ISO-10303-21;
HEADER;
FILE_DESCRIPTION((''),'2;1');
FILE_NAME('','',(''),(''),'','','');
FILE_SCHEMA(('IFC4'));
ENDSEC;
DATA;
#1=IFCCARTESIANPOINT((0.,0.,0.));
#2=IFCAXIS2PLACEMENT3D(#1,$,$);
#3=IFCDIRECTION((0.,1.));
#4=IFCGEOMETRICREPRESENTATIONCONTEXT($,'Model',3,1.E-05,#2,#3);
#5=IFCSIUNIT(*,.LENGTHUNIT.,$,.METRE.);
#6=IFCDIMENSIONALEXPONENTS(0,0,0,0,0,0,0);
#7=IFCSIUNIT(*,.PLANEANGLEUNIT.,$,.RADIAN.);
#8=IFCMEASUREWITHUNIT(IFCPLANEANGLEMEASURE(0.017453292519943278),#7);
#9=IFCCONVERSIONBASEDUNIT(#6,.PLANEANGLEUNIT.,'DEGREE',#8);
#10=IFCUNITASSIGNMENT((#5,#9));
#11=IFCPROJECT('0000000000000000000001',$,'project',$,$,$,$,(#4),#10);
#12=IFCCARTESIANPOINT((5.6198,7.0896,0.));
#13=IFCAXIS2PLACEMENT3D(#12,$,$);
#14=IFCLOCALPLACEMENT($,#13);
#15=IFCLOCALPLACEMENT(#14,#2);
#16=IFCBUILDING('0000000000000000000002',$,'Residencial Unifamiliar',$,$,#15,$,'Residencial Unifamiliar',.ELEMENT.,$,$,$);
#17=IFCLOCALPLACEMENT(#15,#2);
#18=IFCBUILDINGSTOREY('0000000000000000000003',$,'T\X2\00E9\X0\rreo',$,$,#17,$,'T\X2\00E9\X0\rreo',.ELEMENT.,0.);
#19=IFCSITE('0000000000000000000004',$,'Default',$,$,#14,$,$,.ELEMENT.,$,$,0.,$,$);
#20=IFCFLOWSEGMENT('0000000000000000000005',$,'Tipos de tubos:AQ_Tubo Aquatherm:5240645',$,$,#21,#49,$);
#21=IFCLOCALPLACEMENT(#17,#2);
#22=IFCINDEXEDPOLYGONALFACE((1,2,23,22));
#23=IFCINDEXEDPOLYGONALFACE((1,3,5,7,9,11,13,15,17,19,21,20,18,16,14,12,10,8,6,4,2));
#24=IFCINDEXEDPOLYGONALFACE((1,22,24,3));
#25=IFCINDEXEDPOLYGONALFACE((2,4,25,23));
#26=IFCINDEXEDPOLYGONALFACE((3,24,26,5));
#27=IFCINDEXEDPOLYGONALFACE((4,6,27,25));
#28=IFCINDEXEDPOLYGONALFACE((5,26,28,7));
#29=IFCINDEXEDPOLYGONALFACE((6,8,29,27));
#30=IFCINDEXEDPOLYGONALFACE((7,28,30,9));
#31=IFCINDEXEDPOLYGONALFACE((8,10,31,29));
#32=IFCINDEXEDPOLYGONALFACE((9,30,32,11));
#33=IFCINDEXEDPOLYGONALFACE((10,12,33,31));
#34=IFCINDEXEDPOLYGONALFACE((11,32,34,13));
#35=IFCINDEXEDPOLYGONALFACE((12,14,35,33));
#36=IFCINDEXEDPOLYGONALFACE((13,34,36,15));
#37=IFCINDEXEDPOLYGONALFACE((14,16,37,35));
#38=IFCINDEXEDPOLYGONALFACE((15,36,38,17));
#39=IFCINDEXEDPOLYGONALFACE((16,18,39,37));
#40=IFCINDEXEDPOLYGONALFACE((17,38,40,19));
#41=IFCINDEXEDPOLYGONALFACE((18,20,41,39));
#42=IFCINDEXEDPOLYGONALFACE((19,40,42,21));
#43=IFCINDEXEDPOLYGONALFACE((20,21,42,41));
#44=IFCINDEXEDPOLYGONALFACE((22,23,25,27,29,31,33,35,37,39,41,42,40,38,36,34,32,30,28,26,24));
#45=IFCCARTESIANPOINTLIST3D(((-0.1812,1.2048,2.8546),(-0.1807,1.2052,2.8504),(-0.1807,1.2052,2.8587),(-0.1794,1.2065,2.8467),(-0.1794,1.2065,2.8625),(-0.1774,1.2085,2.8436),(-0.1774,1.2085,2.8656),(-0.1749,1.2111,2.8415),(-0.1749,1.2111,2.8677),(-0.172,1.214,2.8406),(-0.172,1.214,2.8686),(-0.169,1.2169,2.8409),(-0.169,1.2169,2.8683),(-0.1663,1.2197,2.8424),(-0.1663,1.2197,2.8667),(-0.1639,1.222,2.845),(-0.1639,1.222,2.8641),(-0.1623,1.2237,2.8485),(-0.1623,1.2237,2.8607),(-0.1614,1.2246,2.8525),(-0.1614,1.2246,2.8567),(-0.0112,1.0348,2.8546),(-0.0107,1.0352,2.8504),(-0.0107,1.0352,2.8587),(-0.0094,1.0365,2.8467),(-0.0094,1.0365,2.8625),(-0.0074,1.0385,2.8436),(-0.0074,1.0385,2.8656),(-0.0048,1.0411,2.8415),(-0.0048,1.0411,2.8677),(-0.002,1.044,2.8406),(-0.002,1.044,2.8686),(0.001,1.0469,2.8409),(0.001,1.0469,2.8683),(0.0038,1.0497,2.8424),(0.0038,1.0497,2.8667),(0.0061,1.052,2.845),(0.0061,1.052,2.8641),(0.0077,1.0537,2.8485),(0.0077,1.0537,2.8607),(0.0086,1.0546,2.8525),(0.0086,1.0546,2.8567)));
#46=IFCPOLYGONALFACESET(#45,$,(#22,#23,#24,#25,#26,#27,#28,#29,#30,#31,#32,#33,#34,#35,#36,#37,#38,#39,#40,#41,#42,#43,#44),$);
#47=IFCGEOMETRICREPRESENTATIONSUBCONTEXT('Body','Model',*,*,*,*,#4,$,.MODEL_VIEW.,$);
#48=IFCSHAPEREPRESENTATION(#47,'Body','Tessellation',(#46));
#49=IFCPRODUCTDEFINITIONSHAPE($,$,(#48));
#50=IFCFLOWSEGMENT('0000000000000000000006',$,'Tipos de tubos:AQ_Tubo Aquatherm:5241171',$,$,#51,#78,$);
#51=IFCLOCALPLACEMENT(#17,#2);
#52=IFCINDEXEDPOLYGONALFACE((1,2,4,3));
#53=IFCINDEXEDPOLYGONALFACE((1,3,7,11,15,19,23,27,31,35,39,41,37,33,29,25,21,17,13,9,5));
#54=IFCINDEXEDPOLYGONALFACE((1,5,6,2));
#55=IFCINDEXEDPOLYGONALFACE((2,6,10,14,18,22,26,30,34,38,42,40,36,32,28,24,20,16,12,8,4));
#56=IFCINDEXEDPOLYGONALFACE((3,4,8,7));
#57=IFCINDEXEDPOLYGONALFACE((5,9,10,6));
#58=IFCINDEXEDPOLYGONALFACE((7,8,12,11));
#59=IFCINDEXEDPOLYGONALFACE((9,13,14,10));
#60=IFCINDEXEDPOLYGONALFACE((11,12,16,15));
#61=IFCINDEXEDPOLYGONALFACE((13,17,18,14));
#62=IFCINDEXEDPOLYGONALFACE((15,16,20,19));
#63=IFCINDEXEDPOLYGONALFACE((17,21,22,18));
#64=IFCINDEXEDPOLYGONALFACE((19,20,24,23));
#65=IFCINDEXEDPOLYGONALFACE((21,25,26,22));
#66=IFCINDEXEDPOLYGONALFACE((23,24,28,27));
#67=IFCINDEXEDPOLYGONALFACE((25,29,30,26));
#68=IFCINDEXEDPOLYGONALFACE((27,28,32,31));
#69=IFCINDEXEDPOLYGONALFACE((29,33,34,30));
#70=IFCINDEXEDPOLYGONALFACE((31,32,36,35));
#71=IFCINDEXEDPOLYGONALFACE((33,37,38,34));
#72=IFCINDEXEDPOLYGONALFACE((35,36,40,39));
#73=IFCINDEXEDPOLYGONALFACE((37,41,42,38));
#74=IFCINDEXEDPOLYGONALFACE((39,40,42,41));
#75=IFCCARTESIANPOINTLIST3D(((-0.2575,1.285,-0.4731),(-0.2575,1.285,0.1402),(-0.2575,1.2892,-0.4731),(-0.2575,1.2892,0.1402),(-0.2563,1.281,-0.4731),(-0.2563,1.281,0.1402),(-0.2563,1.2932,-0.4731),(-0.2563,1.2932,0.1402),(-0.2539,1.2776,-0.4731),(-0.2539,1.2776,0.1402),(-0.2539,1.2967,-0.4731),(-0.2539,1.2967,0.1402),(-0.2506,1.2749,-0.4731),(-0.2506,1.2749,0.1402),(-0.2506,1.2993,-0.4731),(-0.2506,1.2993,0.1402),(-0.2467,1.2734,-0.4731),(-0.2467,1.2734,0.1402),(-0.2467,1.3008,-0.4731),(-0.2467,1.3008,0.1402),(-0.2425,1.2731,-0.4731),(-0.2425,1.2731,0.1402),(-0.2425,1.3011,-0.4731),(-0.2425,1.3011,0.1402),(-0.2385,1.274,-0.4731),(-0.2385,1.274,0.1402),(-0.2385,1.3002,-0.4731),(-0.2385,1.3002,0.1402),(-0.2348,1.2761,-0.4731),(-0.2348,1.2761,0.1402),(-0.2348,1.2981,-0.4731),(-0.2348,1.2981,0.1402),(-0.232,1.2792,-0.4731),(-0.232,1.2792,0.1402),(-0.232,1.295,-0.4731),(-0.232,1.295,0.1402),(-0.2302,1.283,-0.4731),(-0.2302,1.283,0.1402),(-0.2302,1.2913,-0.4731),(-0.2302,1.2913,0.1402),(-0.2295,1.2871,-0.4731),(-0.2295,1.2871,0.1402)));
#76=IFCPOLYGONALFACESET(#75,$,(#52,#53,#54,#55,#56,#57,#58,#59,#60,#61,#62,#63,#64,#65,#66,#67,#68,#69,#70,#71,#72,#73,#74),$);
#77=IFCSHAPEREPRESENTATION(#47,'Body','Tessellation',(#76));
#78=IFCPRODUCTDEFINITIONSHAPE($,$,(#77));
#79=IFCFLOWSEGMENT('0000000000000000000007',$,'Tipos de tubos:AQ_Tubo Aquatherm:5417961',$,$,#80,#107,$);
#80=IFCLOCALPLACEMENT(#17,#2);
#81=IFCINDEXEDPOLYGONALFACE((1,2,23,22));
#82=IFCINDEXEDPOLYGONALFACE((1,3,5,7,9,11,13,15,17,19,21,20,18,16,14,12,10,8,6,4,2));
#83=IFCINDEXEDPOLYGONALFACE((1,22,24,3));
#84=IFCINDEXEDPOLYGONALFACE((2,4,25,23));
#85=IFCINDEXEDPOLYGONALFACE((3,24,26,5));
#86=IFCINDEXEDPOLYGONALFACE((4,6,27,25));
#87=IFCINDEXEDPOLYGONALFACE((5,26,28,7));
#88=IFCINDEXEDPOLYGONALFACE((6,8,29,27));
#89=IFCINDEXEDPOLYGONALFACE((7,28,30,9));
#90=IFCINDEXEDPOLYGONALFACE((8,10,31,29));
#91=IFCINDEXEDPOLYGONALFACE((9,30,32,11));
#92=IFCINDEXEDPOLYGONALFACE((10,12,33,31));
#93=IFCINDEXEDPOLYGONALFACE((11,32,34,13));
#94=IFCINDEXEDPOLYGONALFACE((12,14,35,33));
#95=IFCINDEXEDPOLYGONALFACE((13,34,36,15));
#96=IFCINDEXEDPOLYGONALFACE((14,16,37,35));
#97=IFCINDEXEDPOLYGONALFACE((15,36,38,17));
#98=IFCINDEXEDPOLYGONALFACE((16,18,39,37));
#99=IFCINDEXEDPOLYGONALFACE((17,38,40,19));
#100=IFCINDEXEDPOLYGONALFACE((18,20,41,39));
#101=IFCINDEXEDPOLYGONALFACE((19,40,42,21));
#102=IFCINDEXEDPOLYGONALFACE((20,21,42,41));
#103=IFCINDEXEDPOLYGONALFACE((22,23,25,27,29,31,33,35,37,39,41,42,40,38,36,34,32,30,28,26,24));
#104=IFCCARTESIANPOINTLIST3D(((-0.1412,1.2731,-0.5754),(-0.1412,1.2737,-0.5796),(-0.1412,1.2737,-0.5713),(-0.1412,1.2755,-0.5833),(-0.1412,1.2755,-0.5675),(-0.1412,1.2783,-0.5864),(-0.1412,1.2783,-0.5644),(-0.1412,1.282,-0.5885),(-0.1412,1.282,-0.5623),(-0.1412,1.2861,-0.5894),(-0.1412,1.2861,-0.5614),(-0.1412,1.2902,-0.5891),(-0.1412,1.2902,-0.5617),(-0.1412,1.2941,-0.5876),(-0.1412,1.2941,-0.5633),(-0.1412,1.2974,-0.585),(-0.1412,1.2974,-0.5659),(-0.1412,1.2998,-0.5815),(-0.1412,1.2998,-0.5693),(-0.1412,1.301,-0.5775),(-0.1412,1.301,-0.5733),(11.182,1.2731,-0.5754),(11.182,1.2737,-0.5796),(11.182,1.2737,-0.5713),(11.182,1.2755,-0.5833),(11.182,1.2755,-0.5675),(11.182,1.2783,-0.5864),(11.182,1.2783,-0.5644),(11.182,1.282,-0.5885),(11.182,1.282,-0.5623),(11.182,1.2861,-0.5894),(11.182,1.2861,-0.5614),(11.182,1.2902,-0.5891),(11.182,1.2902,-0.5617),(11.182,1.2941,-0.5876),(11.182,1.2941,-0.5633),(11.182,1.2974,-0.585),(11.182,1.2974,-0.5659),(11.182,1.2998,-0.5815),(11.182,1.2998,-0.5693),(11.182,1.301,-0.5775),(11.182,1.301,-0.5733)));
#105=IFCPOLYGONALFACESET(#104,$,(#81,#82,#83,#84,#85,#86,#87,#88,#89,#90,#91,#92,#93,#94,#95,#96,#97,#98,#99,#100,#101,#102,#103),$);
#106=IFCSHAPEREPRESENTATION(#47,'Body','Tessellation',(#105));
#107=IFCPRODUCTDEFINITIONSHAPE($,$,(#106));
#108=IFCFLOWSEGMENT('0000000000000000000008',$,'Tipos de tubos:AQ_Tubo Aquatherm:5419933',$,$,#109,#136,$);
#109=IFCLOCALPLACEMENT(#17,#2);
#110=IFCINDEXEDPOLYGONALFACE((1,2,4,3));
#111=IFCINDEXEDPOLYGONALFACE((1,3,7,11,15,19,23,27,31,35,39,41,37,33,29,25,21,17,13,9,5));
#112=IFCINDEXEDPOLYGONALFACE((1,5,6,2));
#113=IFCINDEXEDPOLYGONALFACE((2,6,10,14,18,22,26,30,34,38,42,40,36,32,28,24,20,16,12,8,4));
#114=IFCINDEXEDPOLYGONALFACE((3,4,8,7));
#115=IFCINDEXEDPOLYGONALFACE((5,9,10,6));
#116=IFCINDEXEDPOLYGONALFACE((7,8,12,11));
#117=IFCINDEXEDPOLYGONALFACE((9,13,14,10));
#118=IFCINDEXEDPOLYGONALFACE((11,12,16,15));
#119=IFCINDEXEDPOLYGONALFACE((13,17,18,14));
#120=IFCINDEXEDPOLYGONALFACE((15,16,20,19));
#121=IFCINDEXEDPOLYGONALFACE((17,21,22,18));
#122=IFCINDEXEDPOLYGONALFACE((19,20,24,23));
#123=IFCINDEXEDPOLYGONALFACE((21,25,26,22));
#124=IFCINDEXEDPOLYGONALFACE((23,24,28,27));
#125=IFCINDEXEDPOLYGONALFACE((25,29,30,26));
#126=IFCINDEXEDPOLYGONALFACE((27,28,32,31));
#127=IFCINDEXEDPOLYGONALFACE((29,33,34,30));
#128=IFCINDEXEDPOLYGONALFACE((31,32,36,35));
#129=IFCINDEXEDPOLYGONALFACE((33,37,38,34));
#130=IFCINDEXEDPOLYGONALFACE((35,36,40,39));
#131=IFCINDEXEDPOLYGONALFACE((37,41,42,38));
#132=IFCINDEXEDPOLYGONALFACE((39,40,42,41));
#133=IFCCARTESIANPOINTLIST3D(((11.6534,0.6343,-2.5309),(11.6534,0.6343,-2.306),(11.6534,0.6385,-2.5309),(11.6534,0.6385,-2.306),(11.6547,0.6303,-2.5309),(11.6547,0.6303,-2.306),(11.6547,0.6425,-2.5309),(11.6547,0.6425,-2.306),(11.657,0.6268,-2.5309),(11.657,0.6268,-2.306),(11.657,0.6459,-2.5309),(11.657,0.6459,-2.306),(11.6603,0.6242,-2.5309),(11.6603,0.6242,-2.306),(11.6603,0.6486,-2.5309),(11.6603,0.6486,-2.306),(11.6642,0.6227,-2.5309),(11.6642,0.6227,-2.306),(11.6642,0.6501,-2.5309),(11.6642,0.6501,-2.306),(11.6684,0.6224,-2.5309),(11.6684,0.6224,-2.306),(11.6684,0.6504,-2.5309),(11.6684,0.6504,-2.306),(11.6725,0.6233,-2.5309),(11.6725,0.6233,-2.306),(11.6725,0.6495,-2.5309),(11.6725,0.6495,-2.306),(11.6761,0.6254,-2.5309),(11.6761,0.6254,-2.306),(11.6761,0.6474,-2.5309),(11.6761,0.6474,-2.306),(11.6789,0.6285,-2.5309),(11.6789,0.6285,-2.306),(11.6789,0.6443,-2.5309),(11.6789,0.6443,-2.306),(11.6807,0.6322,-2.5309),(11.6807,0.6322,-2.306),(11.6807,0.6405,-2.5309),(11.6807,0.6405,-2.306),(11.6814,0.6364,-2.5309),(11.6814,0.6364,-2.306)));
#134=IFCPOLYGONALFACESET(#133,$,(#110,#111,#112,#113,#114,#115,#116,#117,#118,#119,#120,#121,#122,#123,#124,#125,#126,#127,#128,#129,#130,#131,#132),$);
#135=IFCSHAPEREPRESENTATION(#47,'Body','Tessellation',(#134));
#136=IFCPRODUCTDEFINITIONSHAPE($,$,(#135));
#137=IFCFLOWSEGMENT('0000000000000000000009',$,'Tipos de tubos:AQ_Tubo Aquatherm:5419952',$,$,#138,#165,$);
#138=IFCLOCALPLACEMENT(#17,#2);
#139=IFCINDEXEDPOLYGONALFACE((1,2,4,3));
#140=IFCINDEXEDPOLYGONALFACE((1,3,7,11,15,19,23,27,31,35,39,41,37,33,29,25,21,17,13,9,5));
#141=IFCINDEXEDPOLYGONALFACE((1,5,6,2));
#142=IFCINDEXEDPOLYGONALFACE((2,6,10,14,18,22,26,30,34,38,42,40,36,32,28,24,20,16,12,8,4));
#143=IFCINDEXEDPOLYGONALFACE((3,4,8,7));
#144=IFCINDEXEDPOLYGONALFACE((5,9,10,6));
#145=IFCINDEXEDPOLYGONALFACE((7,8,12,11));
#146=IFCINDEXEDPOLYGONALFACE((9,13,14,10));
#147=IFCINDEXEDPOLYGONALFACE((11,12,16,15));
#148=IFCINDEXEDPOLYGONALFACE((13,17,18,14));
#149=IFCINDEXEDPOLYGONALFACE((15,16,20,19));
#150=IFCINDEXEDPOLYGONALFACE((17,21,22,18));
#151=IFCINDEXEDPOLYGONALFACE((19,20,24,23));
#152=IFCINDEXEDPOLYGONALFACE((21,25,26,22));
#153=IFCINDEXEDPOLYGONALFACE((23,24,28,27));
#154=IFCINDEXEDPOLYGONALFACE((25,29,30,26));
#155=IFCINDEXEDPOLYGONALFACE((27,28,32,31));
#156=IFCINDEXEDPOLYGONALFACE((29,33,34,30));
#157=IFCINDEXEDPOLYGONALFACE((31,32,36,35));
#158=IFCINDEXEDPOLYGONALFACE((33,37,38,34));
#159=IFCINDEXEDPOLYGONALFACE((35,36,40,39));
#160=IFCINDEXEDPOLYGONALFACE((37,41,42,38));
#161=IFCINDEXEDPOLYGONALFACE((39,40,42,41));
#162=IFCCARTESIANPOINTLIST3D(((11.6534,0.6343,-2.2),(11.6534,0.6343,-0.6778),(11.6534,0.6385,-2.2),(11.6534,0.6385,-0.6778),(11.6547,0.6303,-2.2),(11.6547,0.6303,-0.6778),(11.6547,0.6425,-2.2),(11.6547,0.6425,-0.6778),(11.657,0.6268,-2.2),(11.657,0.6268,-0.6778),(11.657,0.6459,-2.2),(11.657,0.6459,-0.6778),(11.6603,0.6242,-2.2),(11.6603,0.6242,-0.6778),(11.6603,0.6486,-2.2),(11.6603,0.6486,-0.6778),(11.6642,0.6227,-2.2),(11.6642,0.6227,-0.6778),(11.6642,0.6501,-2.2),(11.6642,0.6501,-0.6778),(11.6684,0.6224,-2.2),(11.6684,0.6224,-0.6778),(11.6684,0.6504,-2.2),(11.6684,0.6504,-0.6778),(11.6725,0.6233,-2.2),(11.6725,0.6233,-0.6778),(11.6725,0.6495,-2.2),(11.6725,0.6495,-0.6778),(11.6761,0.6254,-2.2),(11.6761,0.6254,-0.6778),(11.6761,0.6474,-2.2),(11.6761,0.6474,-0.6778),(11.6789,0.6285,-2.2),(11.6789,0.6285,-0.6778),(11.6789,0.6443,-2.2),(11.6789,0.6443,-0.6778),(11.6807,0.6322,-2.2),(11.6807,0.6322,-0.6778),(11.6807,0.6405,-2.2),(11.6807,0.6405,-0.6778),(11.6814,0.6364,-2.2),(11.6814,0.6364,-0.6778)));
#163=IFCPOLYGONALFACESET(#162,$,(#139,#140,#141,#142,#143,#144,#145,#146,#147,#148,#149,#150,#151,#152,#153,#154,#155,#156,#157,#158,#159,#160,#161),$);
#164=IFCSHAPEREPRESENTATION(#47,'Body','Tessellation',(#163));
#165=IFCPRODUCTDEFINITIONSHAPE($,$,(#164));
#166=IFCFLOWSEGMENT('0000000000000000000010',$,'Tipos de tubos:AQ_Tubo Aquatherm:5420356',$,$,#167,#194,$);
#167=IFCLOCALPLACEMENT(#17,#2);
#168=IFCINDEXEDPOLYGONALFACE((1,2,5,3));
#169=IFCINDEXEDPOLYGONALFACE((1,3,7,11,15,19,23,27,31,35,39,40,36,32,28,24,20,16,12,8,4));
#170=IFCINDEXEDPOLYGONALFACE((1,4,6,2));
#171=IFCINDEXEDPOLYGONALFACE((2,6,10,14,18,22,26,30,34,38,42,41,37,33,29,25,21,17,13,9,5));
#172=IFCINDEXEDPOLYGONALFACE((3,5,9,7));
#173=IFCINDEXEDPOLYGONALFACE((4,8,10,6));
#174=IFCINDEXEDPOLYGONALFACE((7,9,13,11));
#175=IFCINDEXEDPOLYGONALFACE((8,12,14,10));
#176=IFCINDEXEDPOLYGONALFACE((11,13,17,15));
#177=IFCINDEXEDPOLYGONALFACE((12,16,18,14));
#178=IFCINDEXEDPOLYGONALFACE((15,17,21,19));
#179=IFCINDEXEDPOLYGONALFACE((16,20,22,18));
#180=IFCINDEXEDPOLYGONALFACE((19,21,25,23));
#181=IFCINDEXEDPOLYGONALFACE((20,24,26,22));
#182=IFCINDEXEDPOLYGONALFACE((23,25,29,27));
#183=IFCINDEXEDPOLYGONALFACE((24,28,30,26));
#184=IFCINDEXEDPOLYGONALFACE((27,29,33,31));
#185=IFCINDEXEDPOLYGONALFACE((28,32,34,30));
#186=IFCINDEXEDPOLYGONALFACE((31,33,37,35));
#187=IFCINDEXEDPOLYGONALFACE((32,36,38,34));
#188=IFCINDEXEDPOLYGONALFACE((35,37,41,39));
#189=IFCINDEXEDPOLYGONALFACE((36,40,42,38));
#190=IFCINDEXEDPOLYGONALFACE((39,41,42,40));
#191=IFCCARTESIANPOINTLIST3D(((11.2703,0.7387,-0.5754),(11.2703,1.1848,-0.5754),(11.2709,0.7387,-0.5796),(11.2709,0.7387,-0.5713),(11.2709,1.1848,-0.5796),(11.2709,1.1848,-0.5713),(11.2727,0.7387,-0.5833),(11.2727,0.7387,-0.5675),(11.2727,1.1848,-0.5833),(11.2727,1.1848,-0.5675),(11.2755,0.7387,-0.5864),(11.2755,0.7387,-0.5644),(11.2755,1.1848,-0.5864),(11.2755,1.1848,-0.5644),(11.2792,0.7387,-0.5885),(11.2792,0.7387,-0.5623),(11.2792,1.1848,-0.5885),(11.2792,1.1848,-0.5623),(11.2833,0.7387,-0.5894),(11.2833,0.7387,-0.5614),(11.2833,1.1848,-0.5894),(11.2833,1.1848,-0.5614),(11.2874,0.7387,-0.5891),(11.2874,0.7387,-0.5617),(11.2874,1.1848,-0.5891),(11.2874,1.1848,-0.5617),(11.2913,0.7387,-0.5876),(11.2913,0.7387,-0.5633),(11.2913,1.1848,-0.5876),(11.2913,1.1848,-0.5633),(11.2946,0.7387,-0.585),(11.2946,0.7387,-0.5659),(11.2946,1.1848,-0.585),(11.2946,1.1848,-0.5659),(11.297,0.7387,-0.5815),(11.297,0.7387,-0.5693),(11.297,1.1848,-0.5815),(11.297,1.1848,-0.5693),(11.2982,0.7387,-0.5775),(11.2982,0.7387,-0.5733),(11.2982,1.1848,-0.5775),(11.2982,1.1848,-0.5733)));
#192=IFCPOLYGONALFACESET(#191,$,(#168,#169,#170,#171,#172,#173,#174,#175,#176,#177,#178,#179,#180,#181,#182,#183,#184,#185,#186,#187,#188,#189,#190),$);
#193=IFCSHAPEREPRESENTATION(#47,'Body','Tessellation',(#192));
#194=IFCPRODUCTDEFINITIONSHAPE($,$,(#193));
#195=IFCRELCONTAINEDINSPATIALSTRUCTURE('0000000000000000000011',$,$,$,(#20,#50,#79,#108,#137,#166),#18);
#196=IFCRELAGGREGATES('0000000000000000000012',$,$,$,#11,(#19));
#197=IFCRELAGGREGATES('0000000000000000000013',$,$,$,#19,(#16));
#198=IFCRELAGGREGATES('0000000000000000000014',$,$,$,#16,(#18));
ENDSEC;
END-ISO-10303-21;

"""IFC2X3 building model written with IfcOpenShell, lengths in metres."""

from ifc_helpers import new_model, entity, si_unit, converted_unit, direction, frame, frame_2d, origin, origin_2d_with_axis, place, context, subcontext, project, spatial, circle, extrude, element, save


model = new_model("IFC2X3")

# Units and contexts
model_context = context("Model", 3, precision=1e-05, world=origin(), true_north=direction((0.0, 1.0)))
body_context = subcontext(model_context, "Body", "Model", "MODEL_VIEW")
ifc_project = project(units=[si_unit("LENGTHUNIT", "METRE"), converted_unit("PLANEANGLEUNIT", "DEGREE", entity("IfcPlaneAngleMeasure", 0.017453292519943278), si_unit("PLANEANGLEUNIT", "RADIAN"), dimensions=[0, 0, 0, 0, 0, 0, 0])], contexts=[model_context])

# Site, building, storey
site_placement = place(None, frame((5.6198, 7.0896, 0.0)))
site = spatial("IfcSite", under=ifc_project, at=site_placement, Name="Default", CompositionType="ELEMENT", RefElevation=0.0)
building_placement = place(site_placement, origin())
building = spatial("IfcBuilding", under=site, at=building_placement, Name="Residencial Unifamiliar", LongName="Residencial Unifamiliar", CompositionType="ELEMENT")
storey_placement = place(building_placement, origin())
storey = spatial("IfcBuildingStorey", under=building, at=storey_placement, Name="Térreo", LongName="Térreo", CompositionType="ELEMENT", Elevation=0.0)

# Flow segments
flow_segment_1_placement = place(storey_placement, origin())
element("IfcFlowSegment", 1, at=flow_segment_1_placement, inside=storey, Name="Tipos de tubos:AQ_Tubo Aquatherm:5240645", context=body_context, shape_type="SweptSolid", body=[
    extrude(circle(Radius=0.0141, at=frame_2d((0.0, 0.0), x_axis=(1.0, 0.0))), frame((-0.1712, 1.2147, 2.8546), z_axis=(0.707107, -0.707107, 0.0), x_axis=(-0.707107, -0.707107, 0.0)), (0.0, 0.0, 1.0), 0.2404),
])
flow_segment_2_placement = place(storey_placement, origin())
element("IfcFlowSegment", 2, at=flow_segment_2_placement, inside=storey, Name="Tipos de tubos:AQ_Tubo Aquatherm:5241171", context=body_context, shape_type="SweptSolid", body=[
    extrude(circle(Radius=0.0141, at=origin_2d_with_axis()), frame((-0.2436, 1.2871, -0.4731)), (0.0, 0.0, 1.0), 0.6133),
])
flow_segment_3_placement = place(storey_placement, origin())
element("IfcFlowSegment", 3, at=flow_segment_3_placement, inside=storey, Name="Tipos de tubos:AQ_Tubo Aquatherm:5417961", context=body_context, shape_type="SweptSolid", body=[
    extrude(circle(Radius=0.0141, at=frame_2d((0.0, 0.0), x_axis=(1.0, 0.0))), frame((-0.1412, 1.2871, -0.5754), z_axis=(1.0, 0.0, 0.0), x_axis=(0.0, -1.0, 0.0)), (0.0, 0.0, 1.0), 11.3232),
])
flow_segment_4_placement = place(storey_placement, origin())
element("IfcFlowSegment", 4, at=flow_segment_4_placement, inside=storey, Name="Tipos de tubos:AQ_Tubo Aquatherm:5419933", context=body_context, shape_type="SweptSolid", body=[
    extrude(circle(Radius=0.0141, at=origin_2d_with_axis()), frame((11.6673, 0.6364, -2.5309)), (0.0, 0.0, 1.0), 0.2249),
])
flow_segment_5_placement = place(storey_placement, origin())
element("IfcFlowSegment", 5, at=flow_segment_5_placement, inside=storey, Name="Tipos de tubos:AQ_Tubo Aquatherm:5419952", context=body_context, shape_type="SweptSolid", body=[
    extrude(circle(Radius=0.0141, at=origin_2d_with_axis()), frame((11.6673, 0.6364, -2.2)), (0.0, 0.0, 1.0), 1.5222),
])
flow_segment_6_placement = place(storey_placement, origin())
element("IfcFlowSegment", 6, at=flow_segment_6_placement, inside=storey, Name="Tipos de tubos:AQ_Tubo Aquatherm:5420356", context=body_context, shape_type="SweptSolid", body=[
    extrude(circle(Radius=0.0141, at=origin_2d_with_axis()), frame((11.2843, 0.7387, -0.5754), z_axis=(0.0, 1.0, 0.0), x_axis=(-1.0, 0.0, 0.0)), (0.0, 0.0, 1.0), 0.446),
])

save(model, "model.ifc")
